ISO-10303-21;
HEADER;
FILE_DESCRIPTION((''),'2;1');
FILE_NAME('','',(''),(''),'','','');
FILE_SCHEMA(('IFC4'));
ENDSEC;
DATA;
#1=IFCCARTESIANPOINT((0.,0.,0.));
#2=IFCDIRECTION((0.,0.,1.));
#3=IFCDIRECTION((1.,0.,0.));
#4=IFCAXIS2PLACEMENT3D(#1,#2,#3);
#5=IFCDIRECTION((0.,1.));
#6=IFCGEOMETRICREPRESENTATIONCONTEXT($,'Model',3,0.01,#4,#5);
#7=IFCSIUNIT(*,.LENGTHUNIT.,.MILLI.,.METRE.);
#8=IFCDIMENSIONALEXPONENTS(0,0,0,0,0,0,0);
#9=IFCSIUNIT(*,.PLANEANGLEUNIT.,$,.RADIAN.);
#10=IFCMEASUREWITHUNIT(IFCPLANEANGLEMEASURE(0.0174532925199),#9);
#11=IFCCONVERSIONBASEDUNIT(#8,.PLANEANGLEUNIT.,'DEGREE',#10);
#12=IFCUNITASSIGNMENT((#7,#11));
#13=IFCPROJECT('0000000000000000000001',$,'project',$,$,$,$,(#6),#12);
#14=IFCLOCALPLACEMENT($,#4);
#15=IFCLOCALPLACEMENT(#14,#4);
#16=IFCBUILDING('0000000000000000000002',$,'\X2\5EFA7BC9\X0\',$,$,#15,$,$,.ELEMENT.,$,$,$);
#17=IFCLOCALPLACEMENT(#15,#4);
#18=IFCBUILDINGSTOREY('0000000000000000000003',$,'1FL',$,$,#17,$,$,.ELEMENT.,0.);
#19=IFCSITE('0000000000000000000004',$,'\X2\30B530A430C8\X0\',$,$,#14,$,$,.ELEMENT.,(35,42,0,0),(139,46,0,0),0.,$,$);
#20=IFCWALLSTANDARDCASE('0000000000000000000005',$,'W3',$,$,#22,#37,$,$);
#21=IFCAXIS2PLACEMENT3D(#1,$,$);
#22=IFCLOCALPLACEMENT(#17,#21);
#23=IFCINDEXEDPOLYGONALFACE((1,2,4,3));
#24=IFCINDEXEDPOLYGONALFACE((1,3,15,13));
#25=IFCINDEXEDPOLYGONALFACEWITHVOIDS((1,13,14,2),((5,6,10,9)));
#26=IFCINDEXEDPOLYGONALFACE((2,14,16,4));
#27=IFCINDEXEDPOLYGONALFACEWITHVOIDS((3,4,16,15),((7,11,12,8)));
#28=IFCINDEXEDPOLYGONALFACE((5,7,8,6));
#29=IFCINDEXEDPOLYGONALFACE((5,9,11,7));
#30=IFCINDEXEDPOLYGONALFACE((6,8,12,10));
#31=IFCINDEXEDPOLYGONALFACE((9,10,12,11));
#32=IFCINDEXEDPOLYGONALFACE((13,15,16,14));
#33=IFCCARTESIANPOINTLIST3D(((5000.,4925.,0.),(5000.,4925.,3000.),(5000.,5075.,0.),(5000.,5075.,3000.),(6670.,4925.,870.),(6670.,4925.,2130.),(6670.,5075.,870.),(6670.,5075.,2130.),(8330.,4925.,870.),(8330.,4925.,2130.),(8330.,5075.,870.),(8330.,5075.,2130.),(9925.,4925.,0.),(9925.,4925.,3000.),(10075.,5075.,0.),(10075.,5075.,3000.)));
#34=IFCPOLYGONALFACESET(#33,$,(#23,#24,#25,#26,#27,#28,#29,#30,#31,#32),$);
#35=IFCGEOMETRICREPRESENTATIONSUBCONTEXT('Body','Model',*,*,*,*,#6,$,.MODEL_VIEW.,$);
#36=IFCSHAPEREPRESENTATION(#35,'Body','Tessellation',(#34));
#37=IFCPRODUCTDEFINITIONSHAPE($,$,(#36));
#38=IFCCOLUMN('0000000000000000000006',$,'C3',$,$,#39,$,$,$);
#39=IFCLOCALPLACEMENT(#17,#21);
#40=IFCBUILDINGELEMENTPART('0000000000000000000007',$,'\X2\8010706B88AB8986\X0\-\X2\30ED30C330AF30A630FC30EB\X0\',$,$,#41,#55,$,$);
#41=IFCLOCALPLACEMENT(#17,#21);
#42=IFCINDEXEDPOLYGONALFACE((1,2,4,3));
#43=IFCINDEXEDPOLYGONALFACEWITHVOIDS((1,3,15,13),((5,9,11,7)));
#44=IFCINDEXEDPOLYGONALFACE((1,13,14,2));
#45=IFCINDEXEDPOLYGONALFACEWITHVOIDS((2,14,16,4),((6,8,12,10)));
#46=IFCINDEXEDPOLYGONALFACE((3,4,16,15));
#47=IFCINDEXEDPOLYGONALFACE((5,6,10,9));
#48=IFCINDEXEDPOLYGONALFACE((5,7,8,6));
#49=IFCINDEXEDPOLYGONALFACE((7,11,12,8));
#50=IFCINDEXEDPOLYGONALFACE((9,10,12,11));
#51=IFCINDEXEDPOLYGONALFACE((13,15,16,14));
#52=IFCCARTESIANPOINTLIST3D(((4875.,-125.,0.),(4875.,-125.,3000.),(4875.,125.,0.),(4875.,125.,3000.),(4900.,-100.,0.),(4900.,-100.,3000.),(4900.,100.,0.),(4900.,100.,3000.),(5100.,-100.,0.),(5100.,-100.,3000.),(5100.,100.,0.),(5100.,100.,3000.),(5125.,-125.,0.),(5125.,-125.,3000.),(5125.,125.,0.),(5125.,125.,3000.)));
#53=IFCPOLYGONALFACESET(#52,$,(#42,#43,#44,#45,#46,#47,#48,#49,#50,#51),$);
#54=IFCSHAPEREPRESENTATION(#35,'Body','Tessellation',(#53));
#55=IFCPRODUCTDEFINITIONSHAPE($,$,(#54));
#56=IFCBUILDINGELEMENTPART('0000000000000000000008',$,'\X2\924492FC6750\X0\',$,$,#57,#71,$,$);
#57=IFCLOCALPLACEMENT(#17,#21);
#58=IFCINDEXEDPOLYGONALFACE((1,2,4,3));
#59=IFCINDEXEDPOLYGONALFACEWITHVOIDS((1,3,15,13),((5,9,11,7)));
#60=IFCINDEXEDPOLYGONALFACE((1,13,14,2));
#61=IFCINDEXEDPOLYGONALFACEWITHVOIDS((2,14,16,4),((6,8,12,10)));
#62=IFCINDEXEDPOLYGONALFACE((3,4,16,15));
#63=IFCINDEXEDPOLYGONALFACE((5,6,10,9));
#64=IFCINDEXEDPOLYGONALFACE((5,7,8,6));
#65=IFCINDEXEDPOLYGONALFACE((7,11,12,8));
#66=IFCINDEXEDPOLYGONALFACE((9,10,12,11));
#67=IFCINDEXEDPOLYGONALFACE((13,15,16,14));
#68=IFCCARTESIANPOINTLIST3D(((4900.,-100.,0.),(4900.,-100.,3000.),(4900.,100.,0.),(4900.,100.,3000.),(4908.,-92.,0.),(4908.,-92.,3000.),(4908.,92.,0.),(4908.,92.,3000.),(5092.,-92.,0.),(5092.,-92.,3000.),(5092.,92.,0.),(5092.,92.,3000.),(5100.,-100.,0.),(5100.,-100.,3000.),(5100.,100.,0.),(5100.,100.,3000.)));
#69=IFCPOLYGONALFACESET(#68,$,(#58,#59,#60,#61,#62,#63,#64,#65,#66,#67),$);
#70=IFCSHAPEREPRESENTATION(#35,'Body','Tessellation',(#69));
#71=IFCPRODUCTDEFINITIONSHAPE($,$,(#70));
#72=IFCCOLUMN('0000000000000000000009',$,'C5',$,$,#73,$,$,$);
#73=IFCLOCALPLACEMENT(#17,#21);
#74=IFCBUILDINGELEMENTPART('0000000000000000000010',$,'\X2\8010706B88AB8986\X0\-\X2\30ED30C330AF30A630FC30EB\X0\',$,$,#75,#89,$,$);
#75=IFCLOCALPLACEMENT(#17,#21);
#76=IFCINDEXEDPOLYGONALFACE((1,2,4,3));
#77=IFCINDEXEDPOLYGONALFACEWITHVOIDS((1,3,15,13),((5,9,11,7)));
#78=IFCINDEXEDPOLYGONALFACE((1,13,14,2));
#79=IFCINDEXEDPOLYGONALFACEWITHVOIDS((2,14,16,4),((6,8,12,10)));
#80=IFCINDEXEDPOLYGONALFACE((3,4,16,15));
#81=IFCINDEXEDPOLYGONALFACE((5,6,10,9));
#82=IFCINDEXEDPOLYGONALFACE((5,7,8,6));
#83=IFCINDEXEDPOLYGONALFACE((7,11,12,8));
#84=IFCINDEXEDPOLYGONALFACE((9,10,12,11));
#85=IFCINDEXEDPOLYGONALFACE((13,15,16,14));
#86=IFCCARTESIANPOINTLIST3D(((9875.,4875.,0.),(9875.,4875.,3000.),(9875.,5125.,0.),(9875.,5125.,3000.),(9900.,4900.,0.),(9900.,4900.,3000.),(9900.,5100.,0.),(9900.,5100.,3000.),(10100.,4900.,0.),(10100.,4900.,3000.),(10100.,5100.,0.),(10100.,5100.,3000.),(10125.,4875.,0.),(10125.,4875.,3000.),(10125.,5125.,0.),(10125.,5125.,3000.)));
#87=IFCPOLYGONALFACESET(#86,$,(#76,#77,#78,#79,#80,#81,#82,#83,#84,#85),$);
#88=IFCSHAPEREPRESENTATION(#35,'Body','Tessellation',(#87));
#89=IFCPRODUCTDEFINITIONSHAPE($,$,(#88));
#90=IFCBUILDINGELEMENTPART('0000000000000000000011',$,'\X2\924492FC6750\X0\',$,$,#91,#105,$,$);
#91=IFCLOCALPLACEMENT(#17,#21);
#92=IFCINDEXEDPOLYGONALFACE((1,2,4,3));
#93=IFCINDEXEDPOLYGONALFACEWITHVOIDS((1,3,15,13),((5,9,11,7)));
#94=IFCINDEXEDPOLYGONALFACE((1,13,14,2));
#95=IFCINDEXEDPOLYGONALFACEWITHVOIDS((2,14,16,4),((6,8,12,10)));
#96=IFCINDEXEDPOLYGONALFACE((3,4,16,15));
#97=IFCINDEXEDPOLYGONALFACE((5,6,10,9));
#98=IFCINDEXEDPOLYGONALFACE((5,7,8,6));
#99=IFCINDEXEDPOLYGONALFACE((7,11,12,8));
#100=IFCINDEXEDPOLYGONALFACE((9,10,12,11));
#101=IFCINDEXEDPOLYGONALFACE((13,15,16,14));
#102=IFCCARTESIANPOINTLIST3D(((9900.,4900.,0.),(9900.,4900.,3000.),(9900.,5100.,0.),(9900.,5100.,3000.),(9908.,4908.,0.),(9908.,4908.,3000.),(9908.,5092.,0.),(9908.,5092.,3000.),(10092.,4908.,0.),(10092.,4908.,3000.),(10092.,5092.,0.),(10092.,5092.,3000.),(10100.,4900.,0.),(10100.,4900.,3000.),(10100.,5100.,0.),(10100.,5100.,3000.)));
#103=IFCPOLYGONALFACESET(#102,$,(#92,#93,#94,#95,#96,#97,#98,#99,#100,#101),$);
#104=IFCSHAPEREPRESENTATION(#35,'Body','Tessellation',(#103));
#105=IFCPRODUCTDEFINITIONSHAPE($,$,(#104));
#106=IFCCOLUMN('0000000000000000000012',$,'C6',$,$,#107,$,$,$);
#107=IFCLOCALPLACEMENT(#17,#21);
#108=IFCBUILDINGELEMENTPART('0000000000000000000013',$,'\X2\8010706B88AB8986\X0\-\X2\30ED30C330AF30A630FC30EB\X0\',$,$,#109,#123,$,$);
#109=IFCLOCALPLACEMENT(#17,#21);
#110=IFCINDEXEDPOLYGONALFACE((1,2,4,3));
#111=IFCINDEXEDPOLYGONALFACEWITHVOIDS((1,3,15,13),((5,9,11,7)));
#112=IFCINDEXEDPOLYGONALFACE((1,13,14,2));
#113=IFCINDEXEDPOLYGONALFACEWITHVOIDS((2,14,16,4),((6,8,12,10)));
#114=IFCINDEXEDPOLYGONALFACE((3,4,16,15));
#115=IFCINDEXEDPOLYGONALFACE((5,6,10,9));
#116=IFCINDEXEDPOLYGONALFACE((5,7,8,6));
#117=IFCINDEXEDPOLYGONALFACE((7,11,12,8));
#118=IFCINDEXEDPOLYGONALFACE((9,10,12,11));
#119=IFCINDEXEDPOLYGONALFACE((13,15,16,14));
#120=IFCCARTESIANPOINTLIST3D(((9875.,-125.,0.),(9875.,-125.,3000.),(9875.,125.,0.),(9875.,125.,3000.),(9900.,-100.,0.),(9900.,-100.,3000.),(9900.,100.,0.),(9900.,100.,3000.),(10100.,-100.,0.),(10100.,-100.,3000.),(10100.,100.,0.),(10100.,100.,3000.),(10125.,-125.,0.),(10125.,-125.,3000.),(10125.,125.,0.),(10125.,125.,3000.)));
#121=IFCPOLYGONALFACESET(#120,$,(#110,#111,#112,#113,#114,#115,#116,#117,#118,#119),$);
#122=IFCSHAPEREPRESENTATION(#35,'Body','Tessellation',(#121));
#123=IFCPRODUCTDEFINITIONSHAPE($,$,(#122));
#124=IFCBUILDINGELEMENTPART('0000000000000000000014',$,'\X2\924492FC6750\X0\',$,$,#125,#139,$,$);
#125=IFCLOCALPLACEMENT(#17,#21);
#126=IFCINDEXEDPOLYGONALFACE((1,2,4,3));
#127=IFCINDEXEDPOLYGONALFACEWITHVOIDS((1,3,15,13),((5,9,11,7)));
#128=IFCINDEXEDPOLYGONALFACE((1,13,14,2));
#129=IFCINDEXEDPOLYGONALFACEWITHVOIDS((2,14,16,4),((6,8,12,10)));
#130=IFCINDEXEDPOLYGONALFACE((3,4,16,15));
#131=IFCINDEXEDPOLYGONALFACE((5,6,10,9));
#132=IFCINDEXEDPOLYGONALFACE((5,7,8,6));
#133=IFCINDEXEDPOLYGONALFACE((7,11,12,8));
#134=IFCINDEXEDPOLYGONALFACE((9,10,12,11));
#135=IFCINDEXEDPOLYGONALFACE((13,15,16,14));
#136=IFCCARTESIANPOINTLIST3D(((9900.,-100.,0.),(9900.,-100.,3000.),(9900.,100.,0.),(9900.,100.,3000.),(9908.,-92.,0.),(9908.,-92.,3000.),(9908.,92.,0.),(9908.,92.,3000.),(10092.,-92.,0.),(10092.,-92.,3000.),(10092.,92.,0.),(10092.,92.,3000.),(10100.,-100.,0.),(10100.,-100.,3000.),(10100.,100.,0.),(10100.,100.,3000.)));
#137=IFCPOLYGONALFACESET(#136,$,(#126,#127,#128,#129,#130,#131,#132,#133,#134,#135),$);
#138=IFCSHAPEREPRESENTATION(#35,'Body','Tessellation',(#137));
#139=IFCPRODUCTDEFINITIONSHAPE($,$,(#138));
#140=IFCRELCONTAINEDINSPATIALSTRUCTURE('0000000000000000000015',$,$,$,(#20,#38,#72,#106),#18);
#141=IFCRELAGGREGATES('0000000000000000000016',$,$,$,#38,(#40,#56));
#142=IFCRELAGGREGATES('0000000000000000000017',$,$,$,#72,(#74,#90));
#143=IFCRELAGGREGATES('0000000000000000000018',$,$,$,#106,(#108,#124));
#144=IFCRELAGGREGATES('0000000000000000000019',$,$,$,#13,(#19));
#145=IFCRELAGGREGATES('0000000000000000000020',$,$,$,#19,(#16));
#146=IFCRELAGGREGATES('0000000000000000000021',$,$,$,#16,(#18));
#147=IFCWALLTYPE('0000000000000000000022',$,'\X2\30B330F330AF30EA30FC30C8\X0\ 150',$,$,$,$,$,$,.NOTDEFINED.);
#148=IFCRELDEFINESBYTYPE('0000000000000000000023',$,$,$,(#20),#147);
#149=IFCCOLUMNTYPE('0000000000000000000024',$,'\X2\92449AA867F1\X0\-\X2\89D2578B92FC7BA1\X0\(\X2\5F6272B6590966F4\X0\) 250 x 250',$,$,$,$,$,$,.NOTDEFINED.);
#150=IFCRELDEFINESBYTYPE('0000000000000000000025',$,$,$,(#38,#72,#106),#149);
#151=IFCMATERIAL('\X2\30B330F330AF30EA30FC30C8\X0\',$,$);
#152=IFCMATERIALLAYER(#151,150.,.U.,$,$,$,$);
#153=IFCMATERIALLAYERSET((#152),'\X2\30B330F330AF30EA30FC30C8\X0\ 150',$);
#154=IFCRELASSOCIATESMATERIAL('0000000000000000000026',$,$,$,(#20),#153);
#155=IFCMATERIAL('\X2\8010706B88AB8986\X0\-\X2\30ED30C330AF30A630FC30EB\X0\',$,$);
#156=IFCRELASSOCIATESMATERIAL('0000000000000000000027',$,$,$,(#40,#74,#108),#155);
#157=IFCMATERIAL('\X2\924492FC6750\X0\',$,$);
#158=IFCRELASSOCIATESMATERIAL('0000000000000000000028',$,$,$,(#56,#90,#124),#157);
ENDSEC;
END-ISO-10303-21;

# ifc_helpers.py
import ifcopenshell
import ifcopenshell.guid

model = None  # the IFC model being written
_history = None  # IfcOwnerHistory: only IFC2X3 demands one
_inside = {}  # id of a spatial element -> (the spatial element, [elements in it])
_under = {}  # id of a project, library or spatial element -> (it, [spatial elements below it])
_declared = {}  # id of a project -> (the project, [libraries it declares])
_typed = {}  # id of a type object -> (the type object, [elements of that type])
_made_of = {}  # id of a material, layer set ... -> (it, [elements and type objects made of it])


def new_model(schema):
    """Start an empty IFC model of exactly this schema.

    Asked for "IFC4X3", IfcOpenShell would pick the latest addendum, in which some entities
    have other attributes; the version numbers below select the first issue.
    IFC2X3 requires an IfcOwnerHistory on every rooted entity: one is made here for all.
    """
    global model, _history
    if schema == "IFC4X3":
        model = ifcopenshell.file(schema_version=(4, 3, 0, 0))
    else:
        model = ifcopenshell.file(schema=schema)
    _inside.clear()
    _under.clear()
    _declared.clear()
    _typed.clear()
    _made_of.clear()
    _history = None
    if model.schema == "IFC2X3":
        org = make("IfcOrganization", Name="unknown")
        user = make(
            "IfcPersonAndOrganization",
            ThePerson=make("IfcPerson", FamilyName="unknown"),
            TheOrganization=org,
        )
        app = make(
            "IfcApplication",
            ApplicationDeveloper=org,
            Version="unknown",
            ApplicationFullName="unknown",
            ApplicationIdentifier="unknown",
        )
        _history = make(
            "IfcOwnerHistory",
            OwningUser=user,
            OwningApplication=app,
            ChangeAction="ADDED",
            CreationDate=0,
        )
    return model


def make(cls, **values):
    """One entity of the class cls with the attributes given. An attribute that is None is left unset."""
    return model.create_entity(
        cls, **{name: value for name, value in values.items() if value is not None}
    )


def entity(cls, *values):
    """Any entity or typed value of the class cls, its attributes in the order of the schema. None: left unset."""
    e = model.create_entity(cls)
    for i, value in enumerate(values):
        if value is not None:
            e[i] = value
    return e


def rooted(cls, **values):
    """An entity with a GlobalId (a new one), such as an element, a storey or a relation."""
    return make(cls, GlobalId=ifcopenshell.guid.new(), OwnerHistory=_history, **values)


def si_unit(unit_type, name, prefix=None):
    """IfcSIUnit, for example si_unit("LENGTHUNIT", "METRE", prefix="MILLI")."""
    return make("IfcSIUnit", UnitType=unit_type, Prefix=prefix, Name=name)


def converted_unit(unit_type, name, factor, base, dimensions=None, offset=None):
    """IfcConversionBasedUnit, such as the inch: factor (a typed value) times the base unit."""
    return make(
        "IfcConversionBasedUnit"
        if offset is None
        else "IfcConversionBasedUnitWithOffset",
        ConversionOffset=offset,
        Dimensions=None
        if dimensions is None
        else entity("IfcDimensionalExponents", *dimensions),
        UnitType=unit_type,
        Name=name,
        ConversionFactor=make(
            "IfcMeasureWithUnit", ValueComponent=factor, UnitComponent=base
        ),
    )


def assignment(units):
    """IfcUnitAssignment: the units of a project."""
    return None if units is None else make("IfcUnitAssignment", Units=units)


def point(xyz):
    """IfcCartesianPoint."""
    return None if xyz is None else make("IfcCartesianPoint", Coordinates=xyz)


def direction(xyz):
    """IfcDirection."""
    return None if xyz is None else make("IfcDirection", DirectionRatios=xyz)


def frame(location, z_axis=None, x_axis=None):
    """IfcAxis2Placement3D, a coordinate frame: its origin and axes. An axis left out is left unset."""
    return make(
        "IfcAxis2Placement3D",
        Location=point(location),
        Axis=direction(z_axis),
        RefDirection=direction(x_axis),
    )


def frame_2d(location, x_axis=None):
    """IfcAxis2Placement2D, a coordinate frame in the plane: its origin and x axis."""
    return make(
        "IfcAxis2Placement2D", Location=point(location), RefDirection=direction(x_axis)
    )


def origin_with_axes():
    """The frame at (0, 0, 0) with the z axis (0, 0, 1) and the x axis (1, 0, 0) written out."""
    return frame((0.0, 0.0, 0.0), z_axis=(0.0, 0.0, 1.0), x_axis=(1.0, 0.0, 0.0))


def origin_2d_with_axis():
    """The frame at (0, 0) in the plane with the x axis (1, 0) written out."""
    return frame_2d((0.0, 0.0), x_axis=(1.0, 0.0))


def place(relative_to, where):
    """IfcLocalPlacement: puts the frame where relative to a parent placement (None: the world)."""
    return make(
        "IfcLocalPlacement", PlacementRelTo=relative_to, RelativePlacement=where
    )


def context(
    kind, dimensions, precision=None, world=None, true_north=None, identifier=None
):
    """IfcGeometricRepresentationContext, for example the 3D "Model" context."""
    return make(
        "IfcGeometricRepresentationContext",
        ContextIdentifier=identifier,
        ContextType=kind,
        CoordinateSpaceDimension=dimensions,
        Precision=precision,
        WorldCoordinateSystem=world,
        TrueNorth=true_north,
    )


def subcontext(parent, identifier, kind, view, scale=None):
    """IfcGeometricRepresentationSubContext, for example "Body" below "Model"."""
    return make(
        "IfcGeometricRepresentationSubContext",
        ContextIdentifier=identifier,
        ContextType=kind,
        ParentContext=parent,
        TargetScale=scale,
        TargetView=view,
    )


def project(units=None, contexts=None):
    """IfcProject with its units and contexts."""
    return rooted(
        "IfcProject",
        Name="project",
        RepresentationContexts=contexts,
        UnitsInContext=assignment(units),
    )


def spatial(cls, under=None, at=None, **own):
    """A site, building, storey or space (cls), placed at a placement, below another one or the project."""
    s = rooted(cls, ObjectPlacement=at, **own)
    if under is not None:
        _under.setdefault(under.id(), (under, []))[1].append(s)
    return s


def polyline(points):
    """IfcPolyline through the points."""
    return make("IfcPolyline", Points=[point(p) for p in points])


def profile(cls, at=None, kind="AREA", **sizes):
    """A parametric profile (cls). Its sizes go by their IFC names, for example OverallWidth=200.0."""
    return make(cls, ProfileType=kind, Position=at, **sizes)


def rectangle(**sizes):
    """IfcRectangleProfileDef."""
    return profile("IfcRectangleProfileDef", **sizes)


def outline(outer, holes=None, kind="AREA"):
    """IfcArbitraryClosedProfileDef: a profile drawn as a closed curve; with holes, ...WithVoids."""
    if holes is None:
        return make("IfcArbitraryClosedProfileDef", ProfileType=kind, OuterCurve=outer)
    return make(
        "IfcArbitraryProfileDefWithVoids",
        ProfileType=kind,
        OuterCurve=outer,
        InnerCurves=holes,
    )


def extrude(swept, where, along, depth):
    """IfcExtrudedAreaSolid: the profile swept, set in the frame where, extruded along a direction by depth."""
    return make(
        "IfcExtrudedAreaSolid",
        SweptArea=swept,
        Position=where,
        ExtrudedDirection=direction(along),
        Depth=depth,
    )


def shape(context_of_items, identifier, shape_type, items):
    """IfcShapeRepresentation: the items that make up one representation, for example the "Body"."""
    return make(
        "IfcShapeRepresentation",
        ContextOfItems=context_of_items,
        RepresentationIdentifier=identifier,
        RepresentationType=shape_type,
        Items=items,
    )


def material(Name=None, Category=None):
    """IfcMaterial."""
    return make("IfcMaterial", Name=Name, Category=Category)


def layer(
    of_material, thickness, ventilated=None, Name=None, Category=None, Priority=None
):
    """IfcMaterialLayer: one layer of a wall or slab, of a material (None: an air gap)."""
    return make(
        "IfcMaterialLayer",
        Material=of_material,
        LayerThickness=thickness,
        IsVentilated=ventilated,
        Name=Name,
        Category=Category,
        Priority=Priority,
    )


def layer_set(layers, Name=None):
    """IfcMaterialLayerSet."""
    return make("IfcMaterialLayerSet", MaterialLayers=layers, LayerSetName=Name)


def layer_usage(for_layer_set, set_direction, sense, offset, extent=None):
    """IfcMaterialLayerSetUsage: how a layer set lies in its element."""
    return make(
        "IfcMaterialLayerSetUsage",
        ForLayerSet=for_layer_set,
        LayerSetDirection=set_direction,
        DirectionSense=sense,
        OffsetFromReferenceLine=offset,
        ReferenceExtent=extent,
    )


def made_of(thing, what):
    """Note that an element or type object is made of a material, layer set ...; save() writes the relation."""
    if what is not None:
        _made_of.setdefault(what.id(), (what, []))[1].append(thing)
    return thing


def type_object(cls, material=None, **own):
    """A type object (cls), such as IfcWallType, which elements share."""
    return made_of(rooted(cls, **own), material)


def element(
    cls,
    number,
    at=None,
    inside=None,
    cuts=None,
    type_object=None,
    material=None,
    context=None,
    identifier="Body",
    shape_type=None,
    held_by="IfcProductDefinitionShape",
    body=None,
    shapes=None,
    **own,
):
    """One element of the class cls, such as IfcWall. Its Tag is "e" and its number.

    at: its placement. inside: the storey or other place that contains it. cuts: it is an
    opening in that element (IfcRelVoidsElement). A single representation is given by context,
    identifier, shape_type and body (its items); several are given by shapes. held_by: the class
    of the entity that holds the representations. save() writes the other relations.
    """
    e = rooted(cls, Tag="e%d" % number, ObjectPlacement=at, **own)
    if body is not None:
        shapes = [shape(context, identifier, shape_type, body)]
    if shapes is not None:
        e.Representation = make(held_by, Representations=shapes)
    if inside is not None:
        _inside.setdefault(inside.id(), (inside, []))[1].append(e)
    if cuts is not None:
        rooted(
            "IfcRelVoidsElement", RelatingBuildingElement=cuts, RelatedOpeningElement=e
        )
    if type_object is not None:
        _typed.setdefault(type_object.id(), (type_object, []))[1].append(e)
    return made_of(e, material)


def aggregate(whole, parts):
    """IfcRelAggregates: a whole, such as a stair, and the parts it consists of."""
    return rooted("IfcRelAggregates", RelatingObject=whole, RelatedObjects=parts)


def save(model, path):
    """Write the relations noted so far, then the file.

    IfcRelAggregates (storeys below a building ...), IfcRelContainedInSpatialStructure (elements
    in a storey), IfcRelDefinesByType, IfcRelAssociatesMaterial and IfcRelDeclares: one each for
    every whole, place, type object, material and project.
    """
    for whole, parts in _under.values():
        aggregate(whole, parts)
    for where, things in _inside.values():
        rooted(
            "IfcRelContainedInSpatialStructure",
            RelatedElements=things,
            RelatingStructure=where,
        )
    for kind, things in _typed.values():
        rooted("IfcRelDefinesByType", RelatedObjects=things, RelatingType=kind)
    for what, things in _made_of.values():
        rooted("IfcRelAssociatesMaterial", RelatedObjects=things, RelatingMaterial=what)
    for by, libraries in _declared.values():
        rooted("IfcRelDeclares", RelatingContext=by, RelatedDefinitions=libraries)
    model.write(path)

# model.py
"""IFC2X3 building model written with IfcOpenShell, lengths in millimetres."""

from ifc_helpers import new_model, entity, si_unit, converted_unit, direction, frame, origin_with_axes, origin_2d_with_axis, place, context, subcontext, project, spatial, polyline, rectangle, outline, extrude, material, layer, layer_set, layer_usage, type_object, element, aggregate, save


model = new_model("IFC2X3")

# Units and contexts
model_context = context("Model", 3, precision=0.01, world=origin_with_axes(), true_north=direction((0.0, 1.0)))
body_context = subcontext(model_context, "Body", "Model", "MODEL_VIEW")
ifc_project = project(units=[si_unit("LENGTHUNIT", "METRE", prefix="MILLI"), converted_unit("PLANEANGLEUNIT", "DEGREE", entity("IfcPlaneAngleMeasure", 0.0174532925199), si_unit("PLANEANGLEUNIT", "RADIAN"), dimensions=[0, 0, 0, 0, 0, 0, 0])], contexts=[model_context])

# Site, building, storey
site_placement = place(None, origin_with_axes())
site = spatial("IfcSite", under=ifc_project, at=site_placement, Name="サイト", CompositionType="ELEMENT", RefLatitude=(35, 42, 0, 0), RefLongitude=(139, 46, 0, 0), RefElevation=0.0)
building_placement = place(site_placement, origin_with_axes())
building = spatial("IfcBuilding", under=site, at=building_placement, Name="建築", CompositionType="ELEMENT")
storey_placement = place(building_placement, origin_with_axes())
storey = spatial("IfcBuildingStorey", under=building, at=storey_placement, Name="1FL", CompositionType="ELEMENT", Elevation=0.0)

# Shared definitions
ifc_material_1 = material(Name="コンクリート")

# Wall, opening
ifc_layer_1 = layer(ifc_material_1, 150.0, ventilated="UNKNOWN")
ifc_layer_set_1 = layer_set([ifc_layer_1], Name="コンクリート 150")
wall_type_1 = type_object("IfcWallType", Name="コンクリート 150", PredefinedType="NOTDEFINED")
ifc_layer_usage_1 = layer_usage(ifc_layer_set_1, "AXIS2", "POSITIVE", -75.0)
wall_1_placement = place(storey_placement, frame((10000.0, 5000.0, 0.0), z_axis=(0.0, 0.0, 1.0), x_axis=(-1.0, 0.0, 0.0)))
wall_1 = element("IfcWallStandardCase", 1, at=wall_1_placement, inside=storey, type_object=wall_type_1, material=ifc_layer_usage_1, Name="W3", context=body_context, shape_type="SweptSolid", body=[
    extrude(outline(polyline([(-75.0, -75.0), (5000.0, -75.0), (5000.0, 75.0), (75.0, 75.0), (-75.0, -75.0)])), origin_with_axes(), (0.0, 0.0, 1.0), 3000.0),
])
opening_1_placement = place(wall_1_placement, frame((2500.0, 0.0, 900.0), z_axis=(0.0, 0.0, 1.0), x_axis=(1.0, 0.0, 0.0)))
element("IfcOpeningElement", 2, at=opening_1_placement, cuts=wall_1, context=body_context, shape_type="SweptSolid", body=[
    extrude(rectangle(XDim=1660.0, YDim=1260.0, at=origin_2d_with_axis()), frame((0.0, -195.0, 600.0), z_axis=(0.0, 1.0, 0.0), x_axis=(-1.0, 0.0, 0.0)), (0.0, 0.0, 1.0), 390.0),
])

# Columns, building element parts
column_type_1 = type_object("IfcColumnType", Name="鉄骨柱-角型鋼管(形状変更) 250 x 250", PredefinedType="NOTDEFINED")
column_1_placement = place(storey_placement, frame((5000.0, 0.0, 0.0), z_axis=(0.0, 0.0, 1.0), x_axis=(1.0, 0.0, 0.0)))
column_1 = element("IfcColumn", 3, at=column_1_placement, inside=storey, type_object=column_type_1, Name="C3")
ifc_material_2 = material(Name="耐火被覆-ロックウール")
building_element_part_1_placement = place(column_1_placement, origin_with_axes())
building_element_part_1 = element("IfcBuildingElementPart", 4, at=building_element_part_1_placement, material=ifc_material_2, Name="耐火被覆-ロックウール", context=body_context, shape_type="SweptSolid", body=[
    extrude(outline(polyline([(-125.0, -125.0), (125.0, -125.0), (125.0, 125.0), (-125.0, 125.0), (-125.0, -125.0)]), holes=[polyline([(-100.0, 100.0), (100.0, 100.0), (100.0, -100.0), (-100.0, -100.0), (-100.0, 100.0)])]), origin_with_axes(), (0.0, 0.0, 1.0), 3000.0),
])
ifc_material_3 = material(Name="鉄鋼材")
building_element_part_2_placement = place(column_1_placement, origin_with_axes())
building_element_part_2 = element("IfcBuildingElementPart", 5, at=building_element_part_2_placement, material=ifc_material_3, Name="鉄鋼材", context=body_context, shape_type="SweptSolid", body=[
    extrude(outline(polyline([(-100.0, -100.0), (100.0, -100.0), (100.0, 100.0), (-100.0, 100.0), (-100.0, -100.0)]), holes=[polyline([(92.0, -92.0), (-92.0, -92.0), (-92.0, 92.0), (92.0, 92.0), (92.0, -92.0)])]), origin_with_axes(), (0.0, 0.0, 1.0), 3000.0),
])
aggregate(column_1, [building_element_part_1, building_element_part_2])
column_2_placement = place(storey_placement, frame((10000.0, 5000.0, 0.0), z_axis=(0.0, 0.0, 1.0), x_axis=(1.0, 0.0, 0.0)))
column_2 = element("IfcColumn", 6, at=column_2_placement, inside=storey, type_object=column_type_1, Name="C5")
building_element_part_3_placement = place(column_2_placement, origin_with_axes())
building_element_part_3 = element("IfcBuildingElementPart", 7, at=building_element_part_3_placement, material=ifc_material_2, Name="耐火被覆-ロックウール", context=body_context, shape_type="SweptSolid", body=[
    extrude(outline(polyline([(-125.0, -125.0), (125.0, -125.0), (125.0, 125.0), (-125.0, 125.0), (-125.0, -125.0)]), holes=[polyline([(-100.0, 100.0), (100.0, 100.0), (100.0, -100.0), (-100.0, -100.0), (-100.0, 100.0)])]), origin_with_axes(), (0.0, 0.0, 1.0), 3000.0),
])
building_element_part_4_placement = place(column_2_placement, origin_with_axes())
building_element_part_4 = element("IfcBuildingElementPart", 8, at=building_element_part_4_placement, material=ifc_material_3, Name="鉄鋼材", context=body_context, shape_type="SweptSolid", body=[
    extrude(outline(polyline([(-100.0, -100.0), (100.0, -100.0), (100.0, 100.0), (-100.0, 100.0), (-100.0, -100.0)]), holes=[polyline([(92.0, -92.0), (-92.0, -92.0), (-92.0, 92.0), (92.0, 92.0), (92.0, -92.0)])]), origin_with_axes(), (0.0, 0.0, 1.0), 3000.0),
])
aggregate(column_2, [building_element_part_3, building_element_part_4])
column_3_placement = place(storey_placement, frame((10000.0, 0.0, 0.0), z_axis=(0.0, 0.0, 1.0), x_axis=(1.0, 0.0, 0.0)))
column_3 = element("IfcColumn", 9, at=column_3_placement, inside=storey, type_object=column_type_1, Name="C6")
building_element_part_5_placement = place(column_3_placement, origin_with_axes())
building_element_part_5 = element("IfcBuildingElementPart", 10, at=building_element_part_5_placement, material=ifc_material_2, Name="耐火被覆-ロックウール", context=body_context, shape_type="SweptSolid", body=[
    extrude(outline(polyline([(-125.0, -125.0), (125.0, -125.0), (125.0, 125.0), (-125.0, 125.0), (-125.0, -125.0)]), holes=[polyline([(-100.0, 100.0), (100.0, 100.0), (100.0, -100.0), (-100.0, -100.0), (-100.0, 100.0)])]), origin_with_axes(), (0.0, 0.0, 1.0), 3000.0),
])
building_element_part_6_placement = place(column_3_placement, origin_with_axes())
building_element_part_6 = element("IfcBuildingElementPart", 11, at=building_element_part_6_placement, material=ifc_material_3, Name="鉄鋼材", context=body_context, shape_type="SweptSolid", body=[
    extrude(outline(polyline([(-100.0, -100.0), (100.0, -100.0), (100.0, 100.0), (-100.0, 100.0), (-100.0, -100.0)]), holes=[polyline([(92.0, -92.0), (-92.0, -92.0), (-92.0, 92.0), (92.0, 92.0), (92.0, -92.0)])]), origin_with_axes(), (0.0, 0.0, 1.0), 3000.0),
])
aggregate(column_3, [building_element_part_5, building_element_part_6])

save(model, "model.ifc")
